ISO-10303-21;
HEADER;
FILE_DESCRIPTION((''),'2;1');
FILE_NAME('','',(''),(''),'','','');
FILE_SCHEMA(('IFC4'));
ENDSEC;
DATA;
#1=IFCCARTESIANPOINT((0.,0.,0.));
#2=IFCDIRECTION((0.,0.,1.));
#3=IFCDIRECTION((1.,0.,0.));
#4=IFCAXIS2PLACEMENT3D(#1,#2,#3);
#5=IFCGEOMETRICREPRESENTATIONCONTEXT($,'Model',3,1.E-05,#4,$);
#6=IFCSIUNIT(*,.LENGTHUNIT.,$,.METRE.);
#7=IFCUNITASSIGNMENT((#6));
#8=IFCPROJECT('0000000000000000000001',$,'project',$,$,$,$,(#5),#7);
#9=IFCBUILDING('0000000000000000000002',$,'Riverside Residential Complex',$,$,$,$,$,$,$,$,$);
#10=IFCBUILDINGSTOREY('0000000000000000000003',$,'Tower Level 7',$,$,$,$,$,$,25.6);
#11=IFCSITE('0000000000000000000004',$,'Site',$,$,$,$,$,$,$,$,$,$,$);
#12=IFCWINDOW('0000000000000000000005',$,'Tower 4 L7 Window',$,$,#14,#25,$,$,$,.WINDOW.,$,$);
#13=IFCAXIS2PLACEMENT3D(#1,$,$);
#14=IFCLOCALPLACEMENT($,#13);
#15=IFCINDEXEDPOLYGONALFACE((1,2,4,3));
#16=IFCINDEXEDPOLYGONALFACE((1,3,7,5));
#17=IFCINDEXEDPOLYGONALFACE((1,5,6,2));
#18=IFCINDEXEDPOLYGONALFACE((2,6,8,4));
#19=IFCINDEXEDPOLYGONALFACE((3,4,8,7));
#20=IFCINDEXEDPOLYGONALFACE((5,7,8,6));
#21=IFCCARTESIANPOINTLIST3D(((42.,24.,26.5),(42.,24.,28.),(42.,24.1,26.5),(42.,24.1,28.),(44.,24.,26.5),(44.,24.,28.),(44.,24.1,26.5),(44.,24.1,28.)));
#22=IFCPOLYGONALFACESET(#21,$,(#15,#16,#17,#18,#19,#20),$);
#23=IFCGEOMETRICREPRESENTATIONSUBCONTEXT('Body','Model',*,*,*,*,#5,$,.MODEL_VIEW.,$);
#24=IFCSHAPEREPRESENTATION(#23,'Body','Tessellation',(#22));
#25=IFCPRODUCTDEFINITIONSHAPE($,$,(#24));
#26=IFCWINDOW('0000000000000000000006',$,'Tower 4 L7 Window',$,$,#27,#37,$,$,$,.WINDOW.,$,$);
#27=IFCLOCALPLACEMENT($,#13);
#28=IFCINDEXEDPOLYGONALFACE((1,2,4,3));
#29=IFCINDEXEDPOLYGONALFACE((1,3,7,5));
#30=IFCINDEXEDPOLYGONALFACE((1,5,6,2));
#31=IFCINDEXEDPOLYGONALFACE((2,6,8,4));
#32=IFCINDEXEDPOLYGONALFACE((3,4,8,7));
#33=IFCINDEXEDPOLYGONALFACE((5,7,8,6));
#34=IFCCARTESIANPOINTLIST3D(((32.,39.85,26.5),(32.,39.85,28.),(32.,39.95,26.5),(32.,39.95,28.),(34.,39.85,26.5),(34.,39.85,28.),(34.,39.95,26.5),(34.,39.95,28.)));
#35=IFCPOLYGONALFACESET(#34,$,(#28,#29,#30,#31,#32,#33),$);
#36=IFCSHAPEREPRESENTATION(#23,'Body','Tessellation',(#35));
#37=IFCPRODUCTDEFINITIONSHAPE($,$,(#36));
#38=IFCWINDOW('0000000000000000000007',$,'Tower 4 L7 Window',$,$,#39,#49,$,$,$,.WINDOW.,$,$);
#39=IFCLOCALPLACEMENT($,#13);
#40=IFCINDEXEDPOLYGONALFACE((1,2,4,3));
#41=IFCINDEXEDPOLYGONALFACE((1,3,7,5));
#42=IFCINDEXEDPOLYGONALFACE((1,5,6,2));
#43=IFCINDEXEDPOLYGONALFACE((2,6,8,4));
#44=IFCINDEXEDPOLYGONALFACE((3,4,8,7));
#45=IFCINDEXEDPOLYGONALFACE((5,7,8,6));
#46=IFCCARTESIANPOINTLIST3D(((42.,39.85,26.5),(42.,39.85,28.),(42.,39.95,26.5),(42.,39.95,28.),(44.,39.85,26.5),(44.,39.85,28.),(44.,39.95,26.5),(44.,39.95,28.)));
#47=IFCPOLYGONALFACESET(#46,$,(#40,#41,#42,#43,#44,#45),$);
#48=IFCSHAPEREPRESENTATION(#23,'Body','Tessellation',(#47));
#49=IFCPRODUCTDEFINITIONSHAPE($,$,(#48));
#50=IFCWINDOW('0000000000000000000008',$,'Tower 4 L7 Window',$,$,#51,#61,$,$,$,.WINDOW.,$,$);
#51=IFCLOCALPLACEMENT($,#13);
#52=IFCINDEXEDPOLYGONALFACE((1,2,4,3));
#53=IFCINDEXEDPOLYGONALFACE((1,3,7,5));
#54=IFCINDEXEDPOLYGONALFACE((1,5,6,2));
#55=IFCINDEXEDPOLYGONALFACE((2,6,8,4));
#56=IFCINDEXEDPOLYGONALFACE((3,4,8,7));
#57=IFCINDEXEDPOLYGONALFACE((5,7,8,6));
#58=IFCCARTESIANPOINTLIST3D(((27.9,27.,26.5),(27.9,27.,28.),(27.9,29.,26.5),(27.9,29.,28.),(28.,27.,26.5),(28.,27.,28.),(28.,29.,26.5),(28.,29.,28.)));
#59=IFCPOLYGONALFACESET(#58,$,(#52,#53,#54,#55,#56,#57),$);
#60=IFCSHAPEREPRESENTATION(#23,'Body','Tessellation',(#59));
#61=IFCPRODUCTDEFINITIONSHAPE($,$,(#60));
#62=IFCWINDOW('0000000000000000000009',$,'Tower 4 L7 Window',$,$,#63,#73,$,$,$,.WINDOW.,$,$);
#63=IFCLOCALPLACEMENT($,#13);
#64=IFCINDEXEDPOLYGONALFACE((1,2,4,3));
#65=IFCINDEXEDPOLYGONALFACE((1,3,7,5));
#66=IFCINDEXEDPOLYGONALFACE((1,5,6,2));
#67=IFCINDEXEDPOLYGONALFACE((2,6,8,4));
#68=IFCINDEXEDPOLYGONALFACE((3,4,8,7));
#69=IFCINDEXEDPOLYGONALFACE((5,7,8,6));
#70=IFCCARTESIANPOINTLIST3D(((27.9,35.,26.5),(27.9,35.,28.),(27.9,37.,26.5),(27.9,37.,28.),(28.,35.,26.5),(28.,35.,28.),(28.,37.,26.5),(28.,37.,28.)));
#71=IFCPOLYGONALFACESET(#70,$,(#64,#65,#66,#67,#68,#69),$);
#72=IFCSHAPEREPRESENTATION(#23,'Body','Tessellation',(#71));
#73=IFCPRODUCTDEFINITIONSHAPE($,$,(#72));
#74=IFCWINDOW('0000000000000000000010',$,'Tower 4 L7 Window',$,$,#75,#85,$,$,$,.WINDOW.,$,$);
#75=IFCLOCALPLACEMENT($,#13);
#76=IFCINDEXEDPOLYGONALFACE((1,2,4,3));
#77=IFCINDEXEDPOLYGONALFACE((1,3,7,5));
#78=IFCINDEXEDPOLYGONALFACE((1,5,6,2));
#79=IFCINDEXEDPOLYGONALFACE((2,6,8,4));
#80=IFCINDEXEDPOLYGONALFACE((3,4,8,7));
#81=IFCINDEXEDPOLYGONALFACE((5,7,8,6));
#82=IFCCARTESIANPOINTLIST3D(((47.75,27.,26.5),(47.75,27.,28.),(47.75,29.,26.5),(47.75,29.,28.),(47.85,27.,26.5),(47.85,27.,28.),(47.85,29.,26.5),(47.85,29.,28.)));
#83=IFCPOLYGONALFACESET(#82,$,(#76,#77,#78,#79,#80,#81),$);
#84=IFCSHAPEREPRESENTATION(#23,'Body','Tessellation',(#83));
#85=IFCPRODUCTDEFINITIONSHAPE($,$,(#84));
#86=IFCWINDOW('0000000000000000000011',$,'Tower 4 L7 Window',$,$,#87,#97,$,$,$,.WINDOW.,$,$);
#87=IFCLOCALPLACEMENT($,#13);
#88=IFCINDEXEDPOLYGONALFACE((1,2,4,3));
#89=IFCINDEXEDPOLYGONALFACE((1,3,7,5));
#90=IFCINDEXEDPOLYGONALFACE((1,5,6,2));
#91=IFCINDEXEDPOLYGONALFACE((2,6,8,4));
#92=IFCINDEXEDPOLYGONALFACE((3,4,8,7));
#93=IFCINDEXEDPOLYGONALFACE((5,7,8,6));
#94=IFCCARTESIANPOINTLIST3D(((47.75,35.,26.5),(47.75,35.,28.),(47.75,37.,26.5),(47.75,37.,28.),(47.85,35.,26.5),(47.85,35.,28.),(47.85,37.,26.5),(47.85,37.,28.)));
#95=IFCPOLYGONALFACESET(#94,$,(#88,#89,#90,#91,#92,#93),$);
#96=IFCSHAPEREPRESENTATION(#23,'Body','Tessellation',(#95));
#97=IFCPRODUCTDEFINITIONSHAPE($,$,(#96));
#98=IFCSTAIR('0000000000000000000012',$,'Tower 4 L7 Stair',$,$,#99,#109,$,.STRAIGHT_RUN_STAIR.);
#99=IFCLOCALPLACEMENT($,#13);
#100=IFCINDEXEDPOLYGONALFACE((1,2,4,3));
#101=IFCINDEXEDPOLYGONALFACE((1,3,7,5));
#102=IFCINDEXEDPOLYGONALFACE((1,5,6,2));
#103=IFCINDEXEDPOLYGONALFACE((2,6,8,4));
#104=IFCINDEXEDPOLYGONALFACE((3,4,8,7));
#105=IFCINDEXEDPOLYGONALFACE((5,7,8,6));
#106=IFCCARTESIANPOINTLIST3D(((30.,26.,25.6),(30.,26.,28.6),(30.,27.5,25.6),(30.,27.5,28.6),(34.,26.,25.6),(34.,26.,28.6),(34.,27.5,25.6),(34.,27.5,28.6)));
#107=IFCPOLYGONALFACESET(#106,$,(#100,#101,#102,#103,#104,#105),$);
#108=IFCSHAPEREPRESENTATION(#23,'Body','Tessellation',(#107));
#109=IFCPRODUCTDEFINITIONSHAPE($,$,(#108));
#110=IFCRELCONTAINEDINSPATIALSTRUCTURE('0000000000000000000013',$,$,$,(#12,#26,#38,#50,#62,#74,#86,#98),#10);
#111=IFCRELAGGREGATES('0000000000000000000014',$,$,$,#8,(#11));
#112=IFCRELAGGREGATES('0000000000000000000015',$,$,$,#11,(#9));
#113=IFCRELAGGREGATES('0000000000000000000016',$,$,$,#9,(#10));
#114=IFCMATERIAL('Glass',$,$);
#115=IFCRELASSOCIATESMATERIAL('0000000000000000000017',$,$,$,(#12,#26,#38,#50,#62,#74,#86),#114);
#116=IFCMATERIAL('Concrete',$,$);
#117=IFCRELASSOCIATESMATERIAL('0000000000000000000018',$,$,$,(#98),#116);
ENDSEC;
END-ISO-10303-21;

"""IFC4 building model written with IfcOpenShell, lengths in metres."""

from ifc_helpers import new_model, si_unit, frame, origin_with_axes, place, context, subcontext, project, spatial, line, indexed_curve, outline, extrude, material, element, save


model = new_model("IFC4")

# Units and contexts
model_context = context("Model", 3, precision=1e-05, world=origin_with_axes())
body_context = subcontext(model_context, "Body", "Model", "MODEL_VIEW")
ifc_project = project(units=[si_unit("LENGTHUNIT", "METRE")], contexts=[model_context])

# Site, building, storey
site = spatial("IfcSite", under=ifc_project, Name="Site")
building = spatial("IfcBuilding", under=site, Name="Riverside Residential Complex")
storey = spatial("IfcBuildingStorey", under=building, Name="Tower Level 7", Elevation=25.6)

# Shared definitions
ifc_material_1 = material(Name="Concrete")

# Windows
ifc_material_2 = material(Name="Glass")
for number, where, z_axis, x_axis, name in (
    (1, (42.0, 24.0, 26.5), (0.0, 0.0, 1.0), (1.0, 0.0, 0.0), "Tower 4 L7 Window"),
    (2, (32.0, 39.85, 26.5), (0.0, 0.0, 1.0), (1.0, 0.0, 0.0), "Tower 4 L7 Window"),
    (3, (42.0, 39.85, 26.5), (0.0, 0.0, 1.0), (1.0, 0.0, 0.0), "Tower 4 L7 Window"),
    (4, (28.0, 27.0, 26.5), (0.0, 0.0, 1.0), (0.0, 1.0, 0.0), "Tower 4 L7 Window"),
    (5, (28.0, 35.0, 26.5), (0.0, 0.0, 1.0), (0.0, 1.0, 0.0), "Tower 4 L7 Window"),
    (6, (47.85, 27.0, 26.5), (0.0, 0.0, 1.0), (0.0, 1.0, 0.0), "Tower 4 L7 Window"),
    (7, (47.85, 35.0, 26.5), (0.0, 0.0, 1.0), (0.0, 1.0, 0.0), "Tower 4 L7 Window"),
):
    element("IfcWindow", number, at=place(None, frame(where, z_axis=z_axis, x_axis=x_axis)), inside=storey, material=ifc_material_2, Name=name, PredefinedType="WINDOW", context=body_context, shape_type="SweptSolid", body=[
        extrude(outline(indexed_curve([(0.0, 0.0), (2.0, 0.0), (2.0, 0.1), (0.0, 0.1)], segments=[line(1, 2, 3, 4, 1)])), origin_with_axes(), (0.0, 0.0, 1.0), 1.5),
    ])

# Stair
stair_placement = place(None, frame((30.0, 26.0, 25.6), z_axis=(0.0, 0.0, 1.0), x_axis=(1.0, 0.0, 0.0)))
element("IfcStair", 8, at=stair_placement, inside=storey, material=ifc_material_1, Name="Tower 4 L7 Stair", PredefinedType="STRAIGHT_RUN_STAIR", context=body_context, shape_type="SweptSolid", body=[
    extrude(outline(indexed_curve([(0.0, 0.0), (4.0, 0.0), (4.0, 1.5), (0.0, 1.5)], segments=[line(1, 2, 3, 4, 1)])), origin_with_axes(), (0.0, 0.0, 1.0), 3.0),
])

save(model, "model.ifc")
